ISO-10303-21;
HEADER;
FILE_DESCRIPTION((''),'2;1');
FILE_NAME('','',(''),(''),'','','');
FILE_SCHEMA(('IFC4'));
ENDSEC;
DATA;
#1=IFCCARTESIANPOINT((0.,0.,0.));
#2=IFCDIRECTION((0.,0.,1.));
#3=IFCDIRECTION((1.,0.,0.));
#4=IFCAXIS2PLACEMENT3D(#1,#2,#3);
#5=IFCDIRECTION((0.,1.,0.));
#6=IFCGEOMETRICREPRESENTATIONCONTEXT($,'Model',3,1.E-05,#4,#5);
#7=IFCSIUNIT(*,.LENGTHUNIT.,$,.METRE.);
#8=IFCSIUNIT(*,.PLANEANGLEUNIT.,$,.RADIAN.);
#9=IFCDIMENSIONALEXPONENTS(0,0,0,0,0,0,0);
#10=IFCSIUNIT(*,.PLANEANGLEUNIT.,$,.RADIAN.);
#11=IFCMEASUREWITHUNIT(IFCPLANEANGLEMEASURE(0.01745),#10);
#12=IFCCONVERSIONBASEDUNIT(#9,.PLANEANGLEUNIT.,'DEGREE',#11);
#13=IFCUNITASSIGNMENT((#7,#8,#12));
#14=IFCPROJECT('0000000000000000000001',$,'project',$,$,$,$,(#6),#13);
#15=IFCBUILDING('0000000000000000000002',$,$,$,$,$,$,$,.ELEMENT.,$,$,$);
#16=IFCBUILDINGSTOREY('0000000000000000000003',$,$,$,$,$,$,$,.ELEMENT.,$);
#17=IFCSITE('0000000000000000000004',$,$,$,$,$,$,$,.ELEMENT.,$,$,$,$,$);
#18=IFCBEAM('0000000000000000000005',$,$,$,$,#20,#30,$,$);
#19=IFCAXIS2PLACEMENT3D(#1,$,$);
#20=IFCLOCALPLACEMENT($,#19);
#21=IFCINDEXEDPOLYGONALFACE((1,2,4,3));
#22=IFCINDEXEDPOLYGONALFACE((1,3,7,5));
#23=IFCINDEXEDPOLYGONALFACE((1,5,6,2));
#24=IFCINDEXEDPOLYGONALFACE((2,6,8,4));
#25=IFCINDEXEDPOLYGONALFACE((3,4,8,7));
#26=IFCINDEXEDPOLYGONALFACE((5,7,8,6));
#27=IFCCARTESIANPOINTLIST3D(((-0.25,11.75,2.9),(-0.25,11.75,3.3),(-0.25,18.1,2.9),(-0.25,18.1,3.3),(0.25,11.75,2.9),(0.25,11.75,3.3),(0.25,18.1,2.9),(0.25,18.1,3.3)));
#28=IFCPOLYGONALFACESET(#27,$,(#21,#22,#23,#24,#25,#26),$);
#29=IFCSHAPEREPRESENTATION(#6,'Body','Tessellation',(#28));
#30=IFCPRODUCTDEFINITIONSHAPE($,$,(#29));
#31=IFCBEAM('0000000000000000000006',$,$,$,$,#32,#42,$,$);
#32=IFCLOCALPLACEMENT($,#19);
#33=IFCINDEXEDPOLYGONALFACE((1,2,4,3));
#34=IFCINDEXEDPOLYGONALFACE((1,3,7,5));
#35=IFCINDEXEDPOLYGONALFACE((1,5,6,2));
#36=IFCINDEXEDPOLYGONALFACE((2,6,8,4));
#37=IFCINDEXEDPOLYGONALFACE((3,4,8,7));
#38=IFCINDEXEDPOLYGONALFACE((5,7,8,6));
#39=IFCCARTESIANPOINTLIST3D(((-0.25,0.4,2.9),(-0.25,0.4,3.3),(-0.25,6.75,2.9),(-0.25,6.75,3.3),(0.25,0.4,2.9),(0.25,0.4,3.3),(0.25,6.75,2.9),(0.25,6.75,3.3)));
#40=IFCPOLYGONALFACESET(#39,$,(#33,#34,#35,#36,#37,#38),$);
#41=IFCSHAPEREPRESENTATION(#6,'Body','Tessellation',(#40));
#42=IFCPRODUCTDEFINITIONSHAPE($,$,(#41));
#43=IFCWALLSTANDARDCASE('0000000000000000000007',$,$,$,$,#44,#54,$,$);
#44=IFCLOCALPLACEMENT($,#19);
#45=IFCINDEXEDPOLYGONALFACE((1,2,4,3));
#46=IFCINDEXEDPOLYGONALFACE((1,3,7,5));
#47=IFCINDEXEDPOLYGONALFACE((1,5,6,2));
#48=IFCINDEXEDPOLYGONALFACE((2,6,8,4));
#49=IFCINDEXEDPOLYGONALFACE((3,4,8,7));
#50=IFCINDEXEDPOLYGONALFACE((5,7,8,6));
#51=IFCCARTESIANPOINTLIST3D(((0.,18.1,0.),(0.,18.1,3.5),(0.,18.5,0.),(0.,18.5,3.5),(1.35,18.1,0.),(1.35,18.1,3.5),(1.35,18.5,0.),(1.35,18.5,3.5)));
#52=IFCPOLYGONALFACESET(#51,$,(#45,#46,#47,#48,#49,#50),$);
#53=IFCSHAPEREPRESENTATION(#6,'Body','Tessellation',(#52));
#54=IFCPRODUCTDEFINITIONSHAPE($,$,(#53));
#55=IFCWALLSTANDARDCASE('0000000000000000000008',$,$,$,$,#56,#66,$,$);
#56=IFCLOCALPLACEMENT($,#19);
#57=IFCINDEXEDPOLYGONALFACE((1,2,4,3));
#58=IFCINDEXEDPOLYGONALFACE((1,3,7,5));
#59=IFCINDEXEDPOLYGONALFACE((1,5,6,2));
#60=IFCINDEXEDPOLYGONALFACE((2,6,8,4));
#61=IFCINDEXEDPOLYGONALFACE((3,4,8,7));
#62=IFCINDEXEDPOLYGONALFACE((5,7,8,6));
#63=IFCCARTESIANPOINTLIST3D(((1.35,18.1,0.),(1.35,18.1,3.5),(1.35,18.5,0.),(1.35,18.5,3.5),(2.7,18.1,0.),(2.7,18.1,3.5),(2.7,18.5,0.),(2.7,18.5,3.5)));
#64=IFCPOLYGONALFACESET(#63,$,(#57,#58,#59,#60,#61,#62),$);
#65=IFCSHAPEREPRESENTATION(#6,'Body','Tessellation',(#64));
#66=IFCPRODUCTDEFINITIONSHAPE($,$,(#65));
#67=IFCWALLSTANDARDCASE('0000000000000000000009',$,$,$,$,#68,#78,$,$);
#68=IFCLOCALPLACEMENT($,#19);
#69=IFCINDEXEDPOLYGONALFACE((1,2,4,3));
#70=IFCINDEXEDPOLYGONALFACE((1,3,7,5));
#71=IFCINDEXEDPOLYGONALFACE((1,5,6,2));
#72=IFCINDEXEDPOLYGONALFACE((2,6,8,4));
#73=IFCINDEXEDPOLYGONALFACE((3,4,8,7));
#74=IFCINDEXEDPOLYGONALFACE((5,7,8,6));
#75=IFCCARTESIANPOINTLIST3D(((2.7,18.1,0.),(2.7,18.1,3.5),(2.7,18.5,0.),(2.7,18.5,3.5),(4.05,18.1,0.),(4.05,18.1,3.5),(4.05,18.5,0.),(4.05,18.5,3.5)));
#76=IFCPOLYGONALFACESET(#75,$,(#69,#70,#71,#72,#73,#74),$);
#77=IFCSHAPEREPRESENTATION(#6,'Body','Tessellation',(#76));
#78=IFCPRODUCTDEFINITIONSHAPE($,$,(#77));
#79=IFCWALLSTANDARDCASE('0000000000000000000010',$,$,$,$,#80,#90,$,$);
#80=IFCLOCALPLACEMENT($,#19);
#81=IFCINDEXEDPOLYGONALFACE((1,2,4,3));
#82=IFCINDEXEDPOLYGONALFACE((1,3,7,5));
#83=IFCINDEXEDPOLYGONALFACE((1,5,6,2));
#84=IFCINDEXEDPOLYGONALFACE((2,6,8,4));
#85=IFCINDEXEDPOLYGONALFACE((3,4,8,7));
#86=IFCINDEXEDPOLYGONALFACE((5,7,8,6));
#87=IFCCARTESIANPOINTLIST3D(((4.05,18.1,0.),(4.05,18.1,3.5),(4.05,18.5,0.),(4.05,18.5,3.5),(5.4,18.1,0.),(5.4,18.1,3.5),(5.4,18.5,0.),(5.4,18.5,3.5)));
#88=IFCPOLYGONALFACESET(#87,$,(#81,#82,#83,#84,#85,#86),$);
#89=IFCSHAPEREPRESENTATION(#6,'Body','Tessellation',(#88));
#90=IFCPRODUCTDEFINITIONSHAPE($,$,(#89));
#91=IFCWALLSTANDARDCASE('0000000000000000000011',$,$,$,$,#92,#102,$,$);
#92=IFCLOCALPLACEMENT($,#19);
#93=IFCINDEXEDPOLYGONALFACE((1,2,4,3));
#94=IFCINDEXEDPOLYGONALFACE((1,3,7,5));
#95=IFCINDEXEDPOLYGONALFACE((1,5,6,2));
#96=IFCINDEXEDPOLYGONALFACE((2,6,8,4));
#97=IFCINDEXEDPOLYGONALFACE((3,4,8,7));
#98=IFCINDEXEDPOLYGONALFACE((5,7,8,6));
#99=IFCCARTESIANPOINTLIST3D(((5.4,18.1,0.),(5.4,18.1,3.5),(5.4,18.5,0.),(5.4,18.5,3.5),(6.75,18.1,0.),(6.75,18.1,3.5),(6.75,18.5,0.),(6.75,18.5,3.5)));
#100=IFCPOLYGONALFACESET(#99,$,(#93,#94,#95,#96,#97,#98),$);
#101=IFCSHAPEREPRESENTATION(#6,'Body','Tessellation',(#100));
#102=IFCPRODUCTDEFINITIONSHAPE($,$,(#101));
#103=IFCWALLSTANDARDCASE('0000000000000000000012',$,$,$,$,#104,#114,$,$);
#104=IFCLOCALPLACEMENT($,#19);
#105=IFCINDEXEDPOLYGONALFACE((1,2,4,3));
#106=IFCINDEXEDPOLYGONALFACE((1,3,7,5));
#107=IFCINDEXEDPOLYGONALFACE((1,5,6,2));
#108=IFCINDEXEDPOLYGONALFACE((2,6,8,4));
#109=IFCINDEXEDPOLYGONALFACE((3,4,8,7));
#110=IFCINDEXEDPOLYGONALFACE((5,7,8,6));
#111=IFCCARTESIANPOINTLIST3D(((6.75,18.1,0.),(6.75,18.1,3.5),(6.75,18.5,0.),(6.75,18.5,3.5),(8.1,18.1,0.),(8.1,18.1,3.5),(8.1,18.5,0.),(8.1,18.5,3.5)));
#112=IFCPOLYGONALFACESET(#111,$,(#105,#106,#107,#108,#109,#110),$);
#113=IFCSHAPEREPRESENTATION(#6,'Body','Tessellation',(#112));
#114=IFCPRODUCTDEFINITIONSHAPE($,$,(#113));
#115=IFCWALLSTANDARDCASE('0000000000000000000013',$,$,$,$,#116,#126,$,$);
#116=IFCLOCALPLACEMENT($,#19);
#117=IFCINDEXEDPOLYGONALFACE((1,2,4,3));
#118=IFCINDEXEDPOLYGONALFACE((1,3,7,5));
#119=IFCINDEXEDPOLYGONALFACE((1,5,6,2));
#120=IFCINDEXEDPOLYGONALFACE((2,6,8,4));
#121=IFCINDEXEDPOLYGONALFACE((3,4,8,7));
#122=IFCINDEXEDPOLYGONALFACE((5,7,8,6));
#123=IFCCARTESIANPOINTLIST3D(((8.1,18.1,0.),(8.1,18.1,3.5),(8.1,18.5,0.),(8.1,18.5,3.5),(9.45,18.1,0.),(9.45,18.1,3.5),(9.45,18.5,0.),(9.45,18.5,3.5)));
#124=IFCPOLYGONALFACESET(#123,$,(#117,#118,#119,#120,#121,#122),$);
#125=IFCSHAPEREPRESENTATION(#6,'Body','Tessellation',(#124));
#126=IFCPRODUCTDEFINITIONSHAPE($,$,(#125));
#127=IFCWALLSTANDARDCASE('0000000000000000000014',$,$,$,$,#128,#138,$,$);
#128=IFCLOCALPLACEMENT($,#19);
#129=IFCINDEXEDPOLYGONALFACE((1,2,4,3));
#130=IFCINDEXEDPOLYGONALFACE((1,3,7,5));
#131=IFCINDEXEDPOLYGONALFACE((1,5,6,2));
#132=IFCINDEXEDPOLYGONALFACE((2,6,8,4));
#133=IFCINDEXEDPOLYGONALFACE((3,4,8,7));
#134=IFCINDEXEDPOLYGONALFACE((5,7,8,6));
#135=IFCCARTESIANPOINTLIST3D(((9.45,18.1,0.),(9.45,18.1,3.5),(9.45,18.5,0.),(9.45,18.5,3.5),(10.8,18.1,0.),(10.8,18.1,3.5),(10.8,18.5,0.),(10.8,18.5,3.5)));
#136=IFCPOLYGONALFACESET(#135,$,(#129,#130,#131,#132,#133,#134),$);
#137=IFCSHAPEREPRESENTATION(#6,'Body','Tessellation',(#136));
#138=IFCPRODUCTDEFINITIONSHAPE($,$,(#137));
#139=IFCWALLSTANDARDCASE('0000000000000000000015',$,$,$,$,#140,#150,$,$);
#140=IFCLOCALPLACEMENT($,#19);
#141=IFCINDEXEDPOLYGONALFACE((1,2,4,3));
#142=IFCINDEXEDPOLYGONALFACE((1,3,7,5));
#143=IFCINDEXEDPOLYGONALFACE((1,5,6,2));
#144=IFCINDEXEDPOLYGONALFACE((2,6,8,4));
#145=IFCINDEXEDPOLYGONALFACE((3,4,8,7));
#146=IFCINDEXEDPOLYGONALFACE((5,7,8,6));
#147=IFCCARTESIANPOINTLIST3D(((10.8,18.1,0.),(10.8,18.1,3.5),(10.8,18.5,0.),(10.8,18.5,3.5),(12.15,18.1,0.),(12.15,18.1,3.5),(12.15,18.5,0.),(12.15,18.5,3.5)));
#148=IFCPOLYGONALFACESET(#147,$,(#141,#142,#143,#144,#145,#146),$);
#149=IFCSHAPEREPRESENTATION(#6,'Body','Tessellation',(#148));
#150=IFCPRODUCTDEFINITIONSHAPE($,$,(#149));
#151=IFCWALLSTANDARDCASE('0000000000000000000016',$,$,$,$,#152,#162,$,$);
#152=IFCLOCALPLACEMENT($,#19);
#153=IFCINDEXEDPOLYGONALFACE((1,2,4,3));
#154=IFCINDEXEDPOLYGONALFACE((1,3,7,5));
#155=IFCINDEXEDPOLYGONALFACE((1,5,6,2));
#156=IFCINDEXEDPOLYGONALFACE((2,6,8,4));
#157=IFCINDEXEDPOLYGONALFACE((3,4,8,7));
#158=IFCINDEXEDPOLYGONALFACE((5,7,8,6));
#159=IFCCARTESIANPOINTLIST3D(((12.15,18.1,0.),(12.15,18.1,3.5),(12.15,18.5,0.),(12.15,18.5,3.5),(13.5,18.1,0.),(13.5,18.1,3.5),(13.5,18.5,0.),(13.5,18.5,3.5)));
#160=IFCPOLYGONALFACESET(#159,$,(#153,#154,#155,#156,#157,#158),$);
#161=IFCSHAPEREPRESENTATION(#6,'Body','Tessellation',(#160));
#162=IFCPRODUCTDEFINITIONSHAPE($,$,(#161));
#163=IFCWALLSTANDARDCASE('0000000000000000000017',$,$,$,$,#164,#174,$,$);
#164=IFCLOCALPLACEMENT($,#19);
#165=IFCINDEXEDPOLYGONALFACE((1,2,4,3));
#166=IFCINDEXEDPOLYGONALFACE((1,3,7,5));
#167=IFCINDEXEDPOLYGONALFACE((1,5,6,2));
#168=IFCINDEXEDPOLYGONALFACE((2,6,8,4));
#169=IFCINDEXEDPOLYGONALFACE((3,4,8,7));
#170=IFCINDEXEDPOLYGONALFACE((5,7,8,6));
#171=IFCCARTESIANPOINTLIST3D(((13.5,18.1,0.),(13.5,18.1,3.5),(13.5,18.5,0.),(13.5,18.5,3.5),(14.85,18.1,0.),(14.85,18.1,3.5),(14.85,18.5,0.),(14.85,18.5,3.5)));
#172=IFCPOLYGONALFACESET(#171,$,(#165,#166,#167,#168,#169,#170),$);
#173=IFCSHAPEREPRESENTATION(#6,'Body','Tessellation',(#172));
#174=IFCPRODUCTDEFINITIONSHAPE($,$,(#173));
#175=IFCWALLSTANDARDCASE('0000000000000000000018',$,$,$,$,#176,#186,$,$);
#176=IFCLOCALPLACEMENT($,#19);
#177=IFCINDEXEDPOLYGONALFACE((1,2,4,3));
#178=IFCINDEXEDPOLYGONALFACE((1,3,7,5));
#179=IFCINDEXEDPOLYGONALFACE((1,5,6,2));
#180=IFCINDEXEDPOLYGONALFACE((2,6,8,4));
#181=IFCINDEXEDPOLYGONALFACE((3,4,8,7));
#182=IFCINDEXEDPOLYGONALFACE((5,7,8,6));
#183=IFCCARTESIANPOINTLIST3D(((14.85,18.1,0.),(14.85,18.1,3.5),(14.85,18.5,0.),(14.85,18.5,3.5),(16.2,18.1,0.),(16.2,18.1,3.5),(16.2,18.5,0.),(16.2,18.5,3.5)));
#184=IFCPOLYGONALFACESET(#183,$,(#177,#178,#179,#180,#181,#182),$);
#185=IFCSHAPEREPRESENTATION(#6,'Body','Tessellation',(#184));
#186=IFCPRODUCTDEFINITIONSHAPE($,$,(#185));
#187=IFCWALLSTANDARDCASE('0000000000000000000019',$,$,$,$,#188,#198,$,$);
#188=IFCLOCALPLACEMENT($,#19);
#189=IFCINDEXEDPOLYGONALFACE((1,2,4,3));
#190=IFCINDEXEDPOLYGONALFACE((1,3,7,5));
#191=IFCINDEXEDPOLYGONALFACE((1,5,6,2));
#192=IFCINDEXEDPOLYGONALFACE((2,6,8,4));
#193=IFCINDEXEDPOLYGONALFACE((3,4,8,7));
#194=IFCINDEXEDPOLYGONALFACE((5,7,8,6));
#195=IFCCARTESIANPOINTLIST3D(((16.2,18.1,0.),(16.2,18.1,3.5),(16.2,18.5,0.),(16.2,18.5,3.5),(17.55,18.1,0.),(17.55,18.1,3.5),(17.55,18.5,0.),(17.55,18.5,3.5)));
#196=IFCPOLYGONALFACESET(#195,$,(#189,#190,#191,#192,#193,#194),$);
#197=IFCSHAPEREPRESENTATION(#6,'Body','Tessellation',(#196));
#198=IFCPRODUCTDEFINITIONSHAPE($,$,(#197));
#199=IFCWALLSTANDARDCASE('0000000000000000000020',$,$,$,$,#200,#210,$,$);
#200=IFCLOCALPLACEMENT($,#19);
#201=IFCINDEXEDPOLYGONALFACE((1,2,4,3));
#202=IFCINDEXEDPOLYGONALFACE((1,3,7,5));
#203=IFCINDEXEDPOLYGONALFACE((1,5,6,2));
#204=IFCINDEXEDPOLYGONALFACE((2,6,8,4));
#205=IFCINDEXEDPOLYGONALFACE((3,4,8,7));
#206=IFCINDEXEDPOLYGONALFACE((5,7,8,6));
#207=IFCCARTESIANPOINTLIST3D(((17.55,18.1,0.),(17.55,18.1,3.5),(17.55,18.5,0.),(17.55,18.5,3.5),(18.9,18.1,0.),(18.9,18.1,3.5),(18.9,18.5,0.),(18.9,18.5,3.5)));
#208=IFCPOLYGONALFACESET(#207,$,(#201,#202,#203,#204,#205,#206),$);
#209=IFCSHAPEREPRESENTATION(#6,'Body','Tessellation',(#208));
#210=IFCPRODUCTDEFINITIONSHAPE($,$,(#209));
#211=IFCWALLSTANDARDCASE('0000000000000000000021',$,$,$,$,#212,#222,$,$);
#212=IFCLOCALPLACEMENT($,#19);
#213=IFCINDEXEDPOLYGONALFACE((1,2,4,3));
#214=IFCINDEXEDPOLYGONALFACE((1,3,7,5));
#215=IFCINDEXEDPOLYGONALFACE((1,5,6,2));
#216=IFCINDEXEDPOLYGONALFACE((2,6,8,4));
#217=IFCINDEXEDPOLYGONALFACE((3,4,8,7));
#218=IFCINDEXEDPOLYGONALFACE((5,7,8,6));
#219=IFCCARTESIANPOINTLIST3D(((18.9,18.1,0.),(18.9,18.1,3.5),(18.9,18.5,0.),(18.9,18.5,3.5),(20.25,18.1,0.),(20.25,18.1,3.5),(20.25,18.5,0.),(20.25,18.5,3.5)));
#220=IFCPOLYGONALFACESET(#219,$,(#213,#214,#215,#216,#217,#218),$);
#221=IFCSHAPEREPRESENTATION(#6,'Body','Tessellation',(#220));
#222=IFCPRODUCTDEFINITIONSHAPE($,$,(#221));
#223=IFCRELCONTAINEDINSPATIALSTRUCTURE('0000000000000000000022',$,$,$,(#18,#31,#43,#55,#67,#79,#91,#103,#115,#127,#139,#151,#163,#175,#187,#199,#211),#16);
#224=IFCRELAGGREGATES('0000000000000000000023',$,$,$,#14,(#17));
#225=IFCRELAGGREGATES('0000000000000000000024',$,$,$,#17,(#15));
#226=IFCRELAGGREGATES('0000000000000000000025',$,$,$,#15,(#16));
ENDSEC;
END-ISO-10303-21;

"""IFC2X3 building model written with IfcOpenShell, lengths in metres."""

from ifc_helpers import new_model, entity, si_unit, converted_unit, direction, frame, origin_with_axes, place, context, project, spatial, polyline, outline, extrude, element, save


model = new_model("IFC2X3")

# Units and contexts
model_context = context("Model", 3, precision=1e-05, world=origin_with_axes(), true_north=direction((0.0, 1.0, 0.0)))
ifc_project = project(units=[si_unit("LENGTHUNIT", "METRE"), si_unit("PLANEANGLEUNIT", "RADIAN"), converted_unit("PLANEANGLEUNIT", "DEGREE", entity("IfcPlaneAngleMeasure", 0.01745), si_unit("PLANEANGLEUNIT", "RADIAN"), dimensions=[0, 0, 0, 0, 0, 0, 0])], contexts=[model_context])

# Site, building, storey
site = spatial("IfcSite", under=ifc_project, CompositionType="ELEMENT")
building = spatial("IfcBuilding", under=site, CompositionType="ELEMENT")
storey = spatial("IfcBuildingStorey", under=building, CompositionType="ELEMENT")

# Beams
for number, where, z_axis, x_axis in (
    (1, (0.0, 18.1, 3.1), (0.0, -1.0, 0.0), (-1.0, 0.0, 0.0)),
    (2, (0.0, 0.4, 3.1), (0.0, 1.0, 0.0), (1.0, 0.0, 0.0)),
):
    element("IfcBeam", number, at=place(None, frame(where, z_axis=z_axis, x_axis=x_axis)), inside=storey, context=model_context, shape_type="SweptSolid", body=[
        extrude(outline(polyline([(-0.25, -0.2, 0.0), (0.25, -0.2, 0.0), (0.25, 0.2, 0.0), (-0.25, 0.2, 0.0)])), origin_with_axes(), (0.0, 0.0, 1.0), 6.35),
    ])

# Walls
wall_1_placement = place(None, origin_with_axes())
element("IfcWallStandardCase", 3, at=wall_1_placement, inside=storey, context=model_context, shape_type="SweptSolid", body=[
    extrude(outline(polyline([(0.0, 18.1, 0.0), (1.35, 18.1, 0.0), (1.35, 18.5, 0.0), (0.0, 18.5, 0.0)])), origin_with_axes(), (0.0, 0.0, 1.0), 3.5),
])
wall_2_placement = place(None, origin_with_axes())
element("IfcWallStandardCase", 4, at=wall_2_placement, inside=storey, context=model_context, shape_type="SweptSolid", body=[
    extrude(outline(polyline([(1.35, 18.1, 0.0), (2.7, 18.1, 0.0), (2.7, 18.5, 0.0), (1.35, 18.5, 0.0)])), origin_with_axes(), (0.0, 0.0, 1.0), 3.5),
])
wall_3_placement = place(None, origin_with_axes())
element("IfcWallStandardCase", 5, at=wall_3_placement, inside=storey, context=model_context, shape_type="SweptSolid", body=[
    extrude(outline(polyline([(2.7, 18.1, 0.0), (4.05, 18.1, 0.0), (4.05, 18.5, 0.0), (2.7, 18.5, 0.0)])), origin_with_axes(), (0.0, 0.0, 1.0), 3.5),
])
wall_4_placement = place(None, origin_with_axes())
element("IfcWallStandardCase", 6, at=wall_4_placement, inside=storey, context=model_context, shape_type="SweptSolid", body=[
    extrude(outline(polyline([(4.05, 18.1, 0.0), (5.4, 18.1, 0.0), (5.4, 18.5, 0.0), (4.05, 18.5, 0.0)])), origin_with_axes(), (0.0, 0.0, 1.0), 3.5),
])
wall_5_placement = place(None, origin_with_axes())
element("IfcWallStandardCase", 7, at=wall_5_placement, inside=storey, context=model_context, shape_type="SweptSolid", body=[
    extrude(outline(polyline([(5.4, 18.1, 0.0), (6.75, 18.1, 0.0), (6.75, 18.5, 0.0), (5.4, 18.5, 0.0)])), origin_with_axes(), (0.0, 0.0, 1.0), 3.5),
])
wall_6_placement = place(None, origin_with_axes())
element("IfcWallStandardCase", 8, at=wall_6_placement, inside=storey, context=model_context, shape_type="SweptSolid", body=[
    extrude(outline(polyline([(6.75, 18.1, 0.0), (8.1, 18.1, 0.0), (8.1, 18.5, 0.0), (6.75, 18.5, 0.0)])), origin_with_axes(), (0.0, 0.0, 1.0), 3.5),
])
wall_7_placement = place(None, origin_with_axes())
element("IfcWallStandardCase", 9, at=wall_7_placement, inside=storey, context=model_context, shape_type="SweptSolid", body=[
    extrude(outline(polyline([(8.1, 18.1, 0.0), (9.45, 18.1, 0.0), (9.45, 18.5, 0.0), (8.1, 18.5, 0.0)])), origin_with_axes(), (0.0, 0.0, 1.0), 3.5),
])
wall_8_placement = place(None, origin_with_axes())
element("IfcWallStandardCase", 10, at=wall_8_placement, inside=storey, context=model_context, shape_type="SweptSolid", body=[
    extrude(outline(polyline([(9.45, 18.1, 0.0), (10.8, 18.1, 0.0), (10.8, 18.5, 0.0), (9.45, 18.5, 0.0)])), origin_with_axes(), (0.0, 0.0, 1.0), 3.5),
])
wall_9_placement = place(None, origin_with_axes())
element("IfcWallStandardCase", 11, at=wall_9_placement, inside=storey, context=model_context, shape_type="SweptSolid", body=[
    extrude(outline(polyline([(10.8, 18.1, 0.0), (12.15, 18.1, 0.0), (12.15, 18.5, 0.0), (10.8, 18.5, 0.0)])), origin_with_axes(), (0.0, 0.0, 1.0), 3.5),
])
wall_10_placement = place(None, origin_with_axes())
element("IfcWallStandardCase", 12, at=wall_10_placement, inside=storey, context=model_context, shape_type="SweptSolid", body=[
    extrude(outline(polyline([(12.15, 18.1, 0.0), (13.5, 18.1, 0.0), (13.5, 18.5, 0.0), (12.15, 18.5, 0.0)])), origin_with_axes(), (0.0, 0.0, 1.0), 3.5),
])
wall_11_placement = place(None, origin_with_axes())
element("IfcWallStandardCase", 13, at=wall_11_placement, inside=storey, context=model_context, shape_type="SweptSolid", body=[
    extrude(outline(polyline([(13.5, 18.1, 0.0), (14.85, 18.1, 0.0), (14.85, 18.5, 0.0), (13.5, 18.5, 0.0)])), origin_with_axes(), (0.0, 0.0, 1.0), 3.5),
])
wall_12_placement = place(None, origin_with_axes())
element("IfcWallStandardCase", 14, at=wall_12_placement, inside=storey, context=model_context, shape_type="SweptSolid", body=[
    extrude(outline(polyline([(14.85, 18.1, 0.0), (16.2, 18.1, 0.0), (16.2, 18.5, 0.0), (14.85, 18.5, 0.0)])), origin_with_axes(), (0.0, 0.0, 1.0), 3.5),
])
wall_13_placement = place(None, origin_with_axes())
element("IfcWallStandardCase", 15, at=wall_13_placement, inside=storey, context=model_context, shape_type="SweptSolid", body=[
    extrude(outline(polyline([(16.2, 18.1, 0.0), (17.55, 18.1, 0.0), (17.55, 18.5, 0.0), (16.2, 18.5, 0.0)])), origin_with_axes(), (0.0, 0.0, 1.0), 3.5),
])
wall_14_placement = place(None, origin_with_axes())
element("IfcWallStandardCase", 16, at=wall_14_placement, inside=storey, context=model_context, shape_type="SweptSolid", body=[
    extrude(outline(polyline([(17.55, 18.1, 0.0), (18.9, 18.1, 0.0), (18.9, 18.5, 0.0), (17.55, 18.5, 0.0)])), origin_with_axes(), (0.0, 0.0, 1.0), 3.5),
])
wall_15_placement = place(None, origin_with_axes())
element("IfcWallStandardCase", 17, at=wall_15_placement, inside=storey, context=model_context, shape_type="SweptSolid", body=[
    extrude(outline(polyline([(18.9, 18.1, 0.0), (20.25, 18.1, 0.0), (20.25, 18.5, 0.0), (18.9, 18.5, 0.0)])), origin_with_axes(), (0.0, 0.0, 1.0), 3.5),
])

save(model, "model.ifc")
